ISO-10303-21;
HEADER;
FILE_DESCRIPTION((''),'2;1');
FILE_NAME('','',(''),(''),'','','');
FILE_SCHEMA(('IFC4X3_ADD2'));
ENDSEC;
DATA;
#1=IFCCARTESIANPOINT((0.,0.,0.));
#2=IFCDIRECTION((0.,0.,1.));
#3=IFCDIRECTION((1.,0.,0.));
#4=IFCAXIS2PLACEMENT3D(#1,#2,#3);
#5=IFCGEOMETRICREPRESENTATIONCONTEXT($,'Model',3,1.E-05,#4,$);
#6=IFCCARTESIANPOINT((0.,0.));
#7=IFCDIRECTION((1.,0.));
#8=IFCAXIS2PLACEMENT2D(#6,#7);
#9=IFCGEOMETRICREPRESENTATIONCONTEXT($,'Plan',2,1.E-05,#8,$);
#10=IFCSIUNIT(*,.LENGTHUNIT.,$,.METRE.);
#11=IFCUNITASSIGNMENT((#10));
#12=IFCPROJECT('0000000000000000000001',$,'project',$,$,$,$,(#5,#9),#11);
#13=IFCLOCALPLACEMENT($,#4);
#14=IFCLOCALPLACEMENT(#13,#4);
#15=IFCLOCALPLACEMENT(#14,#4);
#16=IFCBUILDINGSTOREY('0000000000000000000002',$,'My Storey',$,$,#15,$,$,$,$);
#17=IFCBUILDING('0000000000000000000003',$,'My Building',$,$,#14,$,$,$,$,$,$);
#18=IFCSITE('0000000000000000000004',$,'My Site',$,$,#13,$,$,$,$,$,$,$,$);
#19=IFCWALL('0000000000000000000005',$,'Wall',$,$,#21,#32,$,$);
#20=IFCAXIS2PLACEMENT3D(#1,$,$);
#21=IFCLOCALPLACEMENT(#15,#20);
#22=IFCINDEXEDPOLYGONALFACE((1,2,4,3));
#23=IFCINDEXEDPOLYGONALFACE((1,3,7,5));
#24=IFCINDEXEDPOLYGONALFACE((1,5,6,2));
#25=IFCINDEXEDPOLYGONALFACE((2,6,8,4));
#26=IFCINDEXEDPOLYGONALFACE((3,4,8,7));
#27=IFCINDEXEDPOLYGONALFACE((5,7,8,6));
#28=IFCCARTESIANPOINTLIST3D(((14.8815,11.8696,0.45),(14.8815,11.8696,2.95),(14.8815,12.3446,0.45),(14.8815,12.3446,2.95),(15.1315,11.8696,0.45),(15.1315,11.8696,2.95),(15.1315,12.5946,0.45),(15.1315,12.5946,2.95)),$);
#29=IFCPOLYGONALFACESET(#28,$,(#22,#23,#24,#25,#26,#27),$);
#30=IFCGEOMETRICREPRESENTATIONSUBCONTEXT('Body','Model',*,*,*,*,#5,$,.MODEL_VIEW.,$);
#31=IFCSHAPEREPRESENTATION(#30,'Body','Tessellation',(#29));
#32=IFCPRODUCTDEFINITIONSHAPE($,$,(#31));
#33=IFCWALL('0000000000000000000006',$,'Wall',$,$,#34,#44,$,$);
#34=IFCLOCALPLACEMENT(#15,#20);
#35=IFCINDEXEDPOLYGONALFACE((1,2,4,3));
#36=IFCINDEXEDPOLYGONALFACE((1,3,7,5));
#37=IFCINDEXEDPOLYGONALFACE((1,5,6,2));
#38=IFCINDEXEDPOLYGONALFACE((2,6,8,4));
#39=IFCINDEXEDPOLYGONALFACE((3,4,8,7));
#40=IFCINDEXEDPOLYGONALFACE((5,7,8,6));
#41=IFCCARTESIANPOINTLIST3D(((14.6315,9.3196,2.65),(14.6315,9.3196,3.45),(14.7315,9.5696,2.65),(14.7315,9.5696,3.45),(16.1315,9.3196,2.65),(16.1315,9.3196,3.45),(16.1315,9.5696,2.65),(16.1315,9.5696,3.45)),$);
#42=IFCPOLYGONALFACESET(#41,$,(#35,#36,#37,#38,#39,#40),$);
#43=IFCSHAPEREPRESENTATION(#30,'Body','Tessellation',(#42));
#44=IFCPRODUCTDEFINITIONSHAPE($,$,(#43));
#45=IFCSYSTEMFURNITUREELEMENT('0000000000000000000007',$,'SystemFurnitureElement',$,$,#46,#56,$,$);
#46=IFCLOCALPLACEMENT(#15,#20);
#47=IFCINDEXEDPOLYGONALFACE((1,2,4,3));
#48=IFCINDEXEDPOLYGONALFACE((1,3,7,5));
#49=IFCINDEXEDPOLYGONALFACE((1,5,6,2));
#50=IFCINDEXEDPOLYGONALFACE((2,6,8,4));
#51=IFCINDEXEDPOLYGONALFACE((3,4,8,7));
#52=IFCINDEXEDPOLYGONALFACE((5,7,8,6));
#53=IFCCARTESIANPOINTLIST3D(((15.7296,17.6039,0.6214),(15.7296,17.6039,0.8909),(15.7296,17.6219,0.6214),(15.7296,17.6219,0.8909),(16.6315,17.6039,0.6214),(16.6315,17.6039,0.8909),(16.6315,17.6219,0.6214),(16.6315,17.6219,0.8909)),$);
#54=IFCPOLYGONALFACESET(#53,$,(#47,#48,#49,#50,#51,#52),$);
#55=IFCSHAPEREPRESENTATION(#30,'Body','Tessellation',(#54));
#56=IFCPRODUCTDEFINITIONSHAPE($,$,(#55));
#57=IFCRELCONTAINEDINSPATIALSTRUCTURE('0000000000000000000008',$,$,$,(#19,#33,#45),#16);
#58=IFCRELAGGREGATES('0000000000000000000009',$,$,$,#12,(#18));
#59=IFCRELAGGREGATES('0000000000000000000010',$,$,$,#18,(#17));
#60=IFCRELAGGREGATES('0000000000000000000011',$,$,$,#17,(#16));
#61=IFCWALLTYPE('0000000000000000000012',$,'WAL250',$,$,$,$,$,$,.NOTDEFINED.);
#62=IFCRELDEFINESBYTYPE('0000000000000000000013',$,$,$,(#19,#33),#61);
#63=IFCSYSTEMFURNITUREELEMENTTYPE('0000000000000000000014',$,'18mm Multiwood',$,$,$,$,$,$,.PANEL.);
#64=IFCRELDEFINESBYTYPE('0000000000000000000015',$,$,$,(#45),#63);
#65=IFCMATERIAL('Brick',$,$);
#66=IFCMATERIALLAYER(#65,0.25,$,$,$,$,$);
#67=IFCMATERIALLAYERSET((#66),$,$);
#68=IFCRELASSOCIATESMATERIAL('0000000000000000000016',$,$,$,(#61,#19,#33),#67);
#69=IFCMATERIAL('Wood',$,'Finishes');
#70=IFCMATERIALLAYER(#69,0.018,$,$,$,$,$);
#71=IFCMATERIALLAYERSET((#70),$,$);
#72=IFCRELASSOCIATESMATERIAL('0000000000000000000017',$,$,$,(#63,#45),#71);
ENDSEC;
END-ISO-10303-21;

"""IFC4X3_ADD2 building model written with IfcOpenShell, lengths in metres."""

from ifc_helpers import new_model, si_unit, frame, origin_with_axes, origin_2d_with_axis, place, context, subcontext, project, spatial, line, indexed_curve, outline, extrude, material, layer, layer_set, layer_usage, type_object, element, save


model = new_model("IFC4X3_ADD2")

# Units and contexts
model_context = context("Model", 3, precision=1e-05, world=origin_with_axes())
plan_context = context("Plan", 2, precision=1e-05, world=origin_2d_with_axis())
body_context = subcontext(model_context, "Body", "Model", "MODEL_VIEW")
ifc_project = project(units=[si_unit("LENGTHUNIT", "METRE")], contexts=[model_context, plan_context])

# Site, building, storey
site_placement = place(None, origin_with_axes())
site = spatial("IfcSite", under=ifc_project, at=site_placement, Name="My Site")
building_placement = place(site_placement, origin_with_axes())
building = spatial("IfcBuilding", under=site, at=building_placement, Name="My Building")
storey_placement = place(building_placement, origin_with_axes())
storey = spatial("IfcBuildingStorey", under=building, at=storey_placement, Name="My Storey")

# Shared definitions
ifc_material_1 = material(Name="Brick")
ifc_layer_1 = layer(ifc_material_1, 0.25)
ifc_layer_set_1 = layer_set([ifc_layer_1])
wall_type_1 = type_object("IfcWallType", Name="WAL250", PredefinedType="NOTDEFINED", material=ifc_layer_set_1)

# Walls
ifc_layer_usage_1 = layer_usage(ifc_layer_set_1, "AXIS2", "NEGATIVE", 0.0)
wall_1_placement = place(storey_placement, frame((15.1315, 12.5946, 0.45), z_axis=(0.0, 0.0, 1.0), x_axis=(0.000006, -1.0, 0.0)))
element("IfcWall", 1, at=wall_1_placement, inside=storey, type_object=wall_type_1, material=ifc_layer_usage_1, Name="Wall", context=body_context, shape_type="SweptSolid", body=[
    extrude(outline(indexed_curve([(0.25, -0.25), (0.0, 0.0), (0.725, 0.0), (0.725, -0.25)], segments=[line(1, 2, 3, 4, 1)])), origin_with_axes(), (0.0, 0.0, 1.0), 2.5),
])
ifc_layer_usage_2 = layer_usage(ifc_layer_set_1, "AXIS2", "NEGATIVE", 0.0)
wall_2_placement = place(storey_placement, frame((16.1315, 9.3196, 2.65), z_axis=(0.0, 0.0, 1.0), x_axis=(-1.0, -0.000005, 0.0)))
element("IfcWall", 2, at=wall_2_placement, inside=storey, type_object=wall_type_1, material=ifc_layer_usage_2, Name="Wall", context=body_context, shape_type="SweptSolid", body=[
    extrude(outline(indexed_curve([(0.0, -0.25), (0.0, 0.0), (1.5, 0.0), (1.4, -0.25)], segments=[line(1, 2, 3, 4, 1)])), origin_with_axes(), (0.0, 0.0, 1.0), 0.8),
])

# System furniture element
ifc_material_2 = material(Name="Wood", Category="Finishes")
ifc_layer_2 = layer(ifc_material_2, 0.018)
ifc_layer_set_2 = layer_set([ifc_layer_2])
ifc_layer_usage_3 = layer_usage(ifc_layer_set_2, "AXIS2", "POSITIVE", 0.0)
system_furniture_element_type_1 = type_object("IfcSystemFurnitureElementType", Name="18mm Multiwood", PredefinedType="PANEL", material=ifc_layer_set_2)
system_furniture_element_1_placement = place(storey_placement, frame((15.7296, 17.6039, 0.6214), z_axis=(0.0, 0.0, 1.0), x_axis=(1.0, 0.0, 0.0)))
element("IfcSystemFurnitureElement", 3, at=system_furniture_element_1_placement, inside=storey, type_object=system_furniture_element_type_1, material=ifc_layer_usage_3, Name="SystemFurnitureElement", context=body_context, shape_type="SweptSolid", body=[
    extrude(outline(indexed_curve([(0.0, 0.0), (0.0, 0.018), (0.9019, 0.018), (0.9019, 0.0)], segments=[line(1, 2, 3, 4, 1)])), origin_with_axes(), (0.0, 0.0, 1.0), 0.2695),
])

save(model, "model.ifc")
